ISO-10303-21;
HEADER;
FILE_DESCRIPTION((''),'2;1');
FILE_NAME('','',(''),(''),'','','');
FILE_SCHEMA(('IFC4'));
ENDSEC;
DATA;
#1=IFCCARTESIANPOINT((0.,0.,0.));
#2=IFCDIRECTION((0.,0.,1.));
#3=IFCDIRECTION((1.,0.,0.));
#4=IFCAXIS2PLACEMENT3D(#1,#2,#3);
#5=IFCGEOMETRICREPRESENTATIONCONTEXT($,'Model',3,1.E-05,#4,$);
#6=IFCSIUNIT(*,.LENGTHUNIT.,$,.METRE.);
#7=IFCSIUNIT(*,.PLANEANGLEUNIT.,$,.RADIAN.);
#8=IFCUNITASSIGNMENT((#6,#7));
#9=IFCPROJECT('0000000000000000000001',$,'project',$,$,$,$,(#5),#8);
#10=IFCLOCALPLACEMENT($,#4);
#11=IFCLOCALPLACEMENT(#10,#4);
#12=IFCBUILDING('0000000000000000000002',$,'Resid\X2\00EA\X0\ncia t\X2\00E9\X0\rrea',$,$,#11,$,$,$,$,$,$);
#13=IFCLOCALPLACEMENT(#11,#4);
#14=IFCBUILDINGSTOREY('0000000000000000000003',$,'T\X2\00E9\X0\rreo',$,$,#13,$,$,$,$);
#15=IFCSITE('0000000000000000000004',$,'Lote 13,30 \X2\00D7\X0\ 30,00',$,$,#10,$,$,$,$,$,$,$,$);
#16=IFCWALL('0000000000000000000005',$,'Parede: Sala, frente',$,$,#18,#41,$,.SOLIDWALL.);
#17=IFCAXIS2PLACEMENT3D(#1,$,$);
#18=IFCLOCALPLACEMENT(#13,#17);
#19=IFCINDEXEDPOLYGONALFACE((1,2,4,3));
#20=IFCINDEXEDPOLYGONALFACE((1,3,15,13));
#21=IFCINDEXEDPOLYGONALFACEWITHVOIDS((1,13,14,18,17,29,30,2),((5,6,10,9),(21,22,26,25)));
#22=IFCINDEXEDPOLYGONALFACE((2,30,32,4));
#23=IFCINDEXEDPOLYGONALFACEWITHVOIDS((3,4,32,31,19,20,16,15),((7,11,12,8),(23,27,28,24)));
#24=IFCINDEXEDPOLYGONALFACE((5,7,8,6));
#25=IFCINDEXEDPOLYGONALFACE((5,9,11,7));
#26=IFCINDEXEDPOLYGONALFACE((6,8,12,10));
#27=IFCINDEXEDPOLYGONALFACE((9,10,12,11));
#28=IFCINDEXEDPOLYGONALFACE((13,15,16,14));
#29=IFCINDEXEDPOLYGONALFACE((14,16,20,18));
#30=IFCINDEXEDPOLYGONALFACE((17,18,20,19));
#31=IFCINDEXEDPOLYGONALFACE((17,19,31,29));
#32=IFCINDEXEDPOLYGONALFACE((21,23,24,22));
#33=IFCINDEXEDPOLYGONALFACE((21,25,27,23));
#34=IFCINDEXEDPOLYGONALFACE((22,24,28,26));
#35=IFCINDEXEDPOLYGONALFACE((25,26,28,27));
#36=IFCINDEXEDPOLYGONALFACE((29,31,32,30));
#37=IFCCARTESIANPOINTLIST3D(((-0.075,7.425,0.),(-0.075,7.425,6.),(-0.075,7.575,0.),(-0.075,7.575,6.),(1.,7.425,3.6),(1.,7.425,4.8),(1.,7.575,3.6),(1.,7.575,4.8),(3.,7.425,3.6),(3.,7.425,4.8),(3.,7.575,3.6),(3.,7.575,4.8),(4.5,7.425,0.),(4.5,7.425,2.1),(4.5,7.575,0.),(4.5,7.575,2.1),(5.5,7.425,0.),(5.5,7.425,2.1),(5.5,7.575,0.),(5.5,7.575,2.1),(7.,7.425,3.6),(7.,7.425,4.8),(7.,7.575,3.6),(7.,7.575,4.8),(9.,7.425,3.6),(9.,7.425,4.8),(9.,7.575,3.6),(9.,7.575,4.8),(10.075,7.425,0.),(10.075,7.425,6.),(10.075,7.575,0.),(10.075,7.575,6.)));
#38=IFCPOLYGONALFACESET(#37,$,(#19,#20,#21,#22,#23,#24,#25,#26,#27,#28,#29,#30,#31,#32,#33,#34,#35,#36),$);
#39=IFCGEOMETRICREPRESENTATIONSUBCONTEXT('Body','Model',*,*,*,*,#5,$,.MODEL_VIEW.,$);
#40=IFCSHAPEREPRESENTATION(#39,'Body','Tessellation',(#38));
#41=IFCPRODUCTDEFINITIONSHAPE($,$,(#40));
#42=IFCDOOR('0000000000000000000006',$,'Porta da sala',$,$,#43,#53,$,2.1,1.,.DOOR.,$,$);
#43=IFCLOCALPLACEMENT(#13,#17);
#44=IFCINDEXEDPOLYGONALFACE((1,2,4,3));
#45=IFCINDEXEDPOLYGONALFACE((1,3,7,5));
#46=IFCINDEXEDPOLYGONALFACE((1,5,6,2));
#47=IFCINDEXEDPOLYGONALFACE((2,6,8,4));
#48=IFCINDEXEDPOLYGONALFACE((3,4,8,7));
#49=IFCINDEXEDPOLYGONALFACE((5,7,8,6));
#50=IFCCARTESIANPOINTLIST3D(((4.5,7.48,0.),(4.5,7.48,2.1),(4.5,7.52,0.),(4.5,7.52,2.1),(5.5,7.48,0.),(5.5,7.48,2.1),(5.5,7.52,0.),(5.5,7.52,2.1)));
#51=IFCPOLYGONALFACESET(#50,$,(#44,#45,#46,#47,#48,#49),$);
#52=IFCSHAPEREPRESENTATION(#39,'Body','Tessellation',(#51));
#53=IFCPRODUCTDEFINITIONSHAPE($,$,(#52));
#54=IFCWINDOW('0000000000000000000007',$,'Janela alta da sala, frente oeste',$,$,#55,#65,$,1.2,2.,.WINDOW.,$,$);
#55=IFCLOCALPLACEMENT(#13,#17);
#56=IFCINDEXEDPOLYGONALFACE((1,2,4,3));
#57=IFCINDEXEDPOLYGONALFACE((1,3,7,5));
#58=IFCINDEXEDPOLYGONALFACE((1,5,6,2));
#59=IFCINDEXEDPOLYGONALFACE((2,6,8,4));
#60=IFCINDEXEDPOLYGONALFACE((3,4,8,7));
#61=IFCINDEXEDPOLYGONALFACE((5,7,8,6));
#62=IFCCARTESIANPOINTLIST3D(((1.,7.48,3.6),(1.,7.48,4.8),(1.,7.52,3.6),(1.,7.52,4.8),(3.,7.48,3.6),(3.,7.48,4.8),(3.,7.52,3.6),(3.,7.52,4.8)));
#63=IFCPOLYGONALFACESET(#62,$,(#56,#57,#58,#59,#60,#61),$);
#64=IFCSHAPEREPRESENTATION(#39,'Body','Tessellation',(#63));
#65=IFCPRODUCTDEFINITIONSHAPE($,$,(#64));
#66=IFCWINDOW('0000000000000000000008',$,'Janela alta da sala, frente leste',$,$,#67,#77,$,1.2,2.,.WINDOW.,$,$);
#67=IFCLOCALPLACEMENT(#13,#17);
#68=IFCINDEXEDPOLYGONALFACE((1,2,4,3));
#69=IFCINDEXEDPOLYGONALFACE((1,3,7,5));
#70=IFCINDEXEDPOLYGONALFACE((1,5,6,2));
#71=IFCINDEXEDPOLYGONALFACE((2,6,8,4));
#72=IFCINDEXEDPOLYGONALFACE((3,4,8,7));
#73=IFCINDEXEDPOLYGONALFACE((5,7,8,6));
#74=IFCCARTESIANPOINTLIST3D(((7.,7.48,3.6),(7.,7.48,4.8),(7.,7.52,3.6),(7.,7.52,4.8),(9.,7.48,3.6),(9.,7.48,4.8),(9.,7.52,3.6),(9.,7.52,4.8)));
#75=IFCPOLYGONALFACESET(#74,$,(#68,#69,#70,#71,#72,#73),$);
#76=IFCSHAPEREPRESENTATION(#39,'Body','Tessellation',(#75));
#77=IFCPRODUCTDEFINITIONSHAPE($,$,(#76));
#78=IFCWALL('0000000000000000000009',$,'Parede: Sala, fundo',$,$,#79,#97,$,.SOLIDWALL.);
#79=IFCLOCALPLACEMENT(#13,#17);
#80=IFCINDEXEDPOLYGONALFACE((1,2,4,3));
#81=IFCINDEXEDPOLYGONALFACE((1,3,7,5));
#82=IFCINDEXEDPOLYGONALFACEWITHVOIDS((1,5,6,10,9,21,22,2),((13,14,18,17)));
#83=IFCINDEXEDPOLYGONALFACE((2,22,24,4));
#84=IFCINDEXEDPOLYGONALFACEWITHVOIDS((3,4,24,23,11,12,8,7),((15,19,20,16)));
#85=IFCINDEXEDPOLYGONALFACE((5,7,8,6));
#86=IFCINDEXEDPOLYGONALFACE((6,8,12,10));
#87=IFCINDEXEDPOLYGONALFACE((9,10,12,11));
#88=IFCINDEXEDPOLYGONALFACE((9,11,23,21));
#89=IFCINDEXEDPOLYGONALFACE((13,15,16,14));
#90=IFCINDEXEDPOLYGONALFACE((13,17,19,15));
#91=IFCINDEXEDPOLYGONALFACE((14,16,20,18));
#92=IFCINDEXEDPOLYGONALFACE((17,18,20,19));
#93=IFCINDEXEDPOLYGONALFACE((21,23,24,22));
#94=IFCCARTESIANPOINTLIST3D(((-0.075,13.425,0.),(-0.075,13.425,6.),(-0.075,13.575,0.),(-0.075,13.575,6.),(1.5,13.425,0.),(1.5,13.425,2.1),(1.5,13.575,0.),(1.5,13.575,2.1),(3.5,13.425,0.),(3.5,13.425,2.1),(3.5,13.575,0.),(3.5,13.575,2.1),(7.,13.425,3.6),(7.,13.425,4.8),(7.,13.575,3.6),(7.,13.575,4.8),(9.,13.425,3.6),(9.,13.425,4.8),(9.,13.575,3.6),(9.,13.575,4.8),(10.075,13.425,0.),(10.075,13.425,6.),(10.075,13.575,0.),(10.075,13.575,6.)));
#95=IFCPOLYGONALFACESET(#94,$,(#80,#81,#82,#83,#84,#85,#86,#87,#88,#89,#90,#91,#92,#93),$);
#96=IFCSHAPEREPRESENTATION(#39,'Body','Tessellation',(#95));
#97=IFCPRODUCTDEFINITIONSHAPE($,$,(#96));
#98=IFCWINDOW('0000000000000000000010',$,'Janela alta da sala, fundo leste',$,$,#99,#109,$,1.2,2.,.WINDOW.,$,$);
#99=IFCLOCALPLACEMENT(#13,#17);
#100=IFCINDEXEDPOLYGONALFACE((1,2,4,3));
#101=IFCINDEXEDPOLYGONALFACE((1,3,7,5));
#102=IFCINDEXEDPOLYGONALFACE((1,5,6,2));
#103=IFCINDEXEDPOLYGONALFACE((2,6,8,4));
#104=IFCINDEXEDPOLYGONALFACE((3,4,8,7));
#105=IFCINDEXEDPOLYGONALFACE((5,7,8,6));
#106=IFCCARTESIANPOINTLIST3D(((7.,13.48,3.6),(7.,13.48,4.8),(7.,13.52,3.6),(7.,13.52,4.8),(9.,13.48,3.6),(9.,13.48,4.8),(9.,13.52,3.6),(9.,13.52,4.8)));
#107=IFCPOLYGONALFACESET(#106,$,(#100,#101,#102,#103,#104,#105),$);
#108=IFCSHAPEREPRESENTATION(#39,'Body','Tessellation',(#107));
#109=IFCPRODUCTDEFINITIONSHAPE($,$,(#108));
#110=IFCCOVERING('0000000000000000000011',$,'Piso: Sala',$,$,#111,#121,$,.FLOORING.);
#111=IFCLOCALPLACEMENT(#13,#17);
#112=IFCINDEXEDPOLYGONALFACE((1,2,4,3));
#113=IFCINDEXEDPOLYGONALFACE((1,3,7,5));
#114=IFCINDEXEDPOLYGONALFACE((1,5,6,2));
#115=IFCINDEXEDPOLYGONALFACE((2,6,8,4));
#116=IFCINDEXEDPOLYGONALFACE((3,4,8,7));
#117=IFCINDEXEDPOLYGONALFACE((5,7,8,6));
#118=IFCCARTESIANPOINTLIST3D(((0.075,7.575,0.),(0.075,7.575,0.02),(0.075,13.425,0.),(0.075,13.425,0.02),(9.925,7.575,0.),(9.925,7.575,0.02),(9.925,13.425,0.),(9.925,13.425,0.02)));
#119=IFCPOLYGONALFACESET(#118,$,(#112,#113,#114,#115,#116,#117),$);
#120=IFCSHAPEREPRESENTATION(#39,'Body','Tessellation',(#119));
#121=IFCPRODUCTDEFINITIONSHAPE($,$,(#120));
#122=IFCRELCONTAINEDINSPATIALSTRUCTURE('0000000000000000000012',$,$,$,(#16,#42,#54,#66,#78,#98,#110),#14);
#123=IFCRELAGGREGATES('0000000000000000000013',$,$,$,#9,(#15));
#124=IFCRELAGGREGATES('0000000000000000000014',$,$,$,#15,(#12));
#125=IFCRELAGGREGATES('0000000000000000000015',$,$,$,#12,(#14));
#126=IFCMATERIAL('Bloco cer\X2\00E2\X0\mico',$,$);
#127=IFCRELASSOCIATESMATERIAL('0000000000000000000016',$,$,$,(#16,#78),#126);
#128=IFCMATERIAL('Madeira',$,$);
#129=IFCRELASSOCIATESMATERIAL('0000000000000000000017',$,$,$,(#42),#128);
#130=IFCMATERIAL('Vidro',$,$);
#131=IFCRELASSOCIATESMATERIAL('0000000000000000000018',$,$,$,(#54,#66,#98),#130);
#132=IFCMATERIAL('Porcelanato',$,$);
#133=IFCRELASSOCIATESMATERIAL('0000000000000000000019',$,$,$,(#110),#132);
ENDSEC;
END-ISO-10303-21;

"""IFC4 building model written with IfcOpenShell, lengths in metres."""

from ifc_helpers import new_model, si_unit, frame, origin_with_axes, place, context, subcontext, project, spatial, line, indexed_curve, outline, extrude, material, element, fill, save


model = new_model("IFC4")

# Units and contexts
model_context = context("Model", 3, precision=1e-05, world=origin_with_axes())
body_context = subcontext(model_context, "Body", "Model", "MODEL_VIEW")
ifc_project = project(units=[si_unit("LENGTHUNIT", "METRE"), si_unit("PLANEANGLEUNIT", "RADIAN")], contexts=[model_context])

# Site, building, storey
site_placement = place(None, origin_with_axes())
site = spatial("IfcSite", under=ifc_project, at=site_placement, Name="Lote 13,30 × 30,00")
building_placement = place(site_placement, origin_with_axes())
building = spatial("IfcBuilding", under=site, at=building_placement, Name="Residência térrea")
storey_placement = place(building_placement, origin_with_axes())
storey = spatial("IfcBuildingStorey", under=building, at=storey_placement, Name="Térreo")

# Shared definitions
ifc_material_1 = material(Name="Concreto armado")

# Shared definitions
ifc_material_2 = material(Name="Bloco cerâmico")
ifc_material_3 = material(Name="Vidro")

# Wall, openings, door, windows
wall_1_placement = place(storey_placement, frame((-0.075, 7.425, 0.0), z_axis=(0.0, 0.0, 1.0), x_axis=(1.0, 0.0, 0.0)))
wall_1 = element("IfcWall", 1, at=wall_1_placement, inside=storey, material=ifc_material_2, Name="Parede: Sala, frente", PredefinedType="SOLIDWALL", context=body_context, shape_type="SweptSolid", body=[
    extrude(outline(indexed_curve([(0.0, 0.0), (10.15, 0.0), (10.15, 0.15), (0.0, 0.15)], segments=[line(1, 2, 3, 4, 1)])), origin_with_axes(), (0.0, 0.0, 1.0), 6.0),
])
opening_1_placement = place(wall_1_placement, frame((4.575, -0.05, 0.0), z_axis=(0.0, 0.0, 1.0), x_axis=(1.0, 0.0, 0.0)))
opening_1 = element("IfcOpeningElement", 2, at=opening_1_placement, cuts=wall_1, material=ifc_material_1, PredefinedType="OPENING", context=body_context, shape_type="SweptSolid", body=[
    extrude(outline(indexed_curve([(0.0, 0.0), (1.0, 0.0), (1.0, 0.25), (0.0, 0.25)], segments=[line(1, 2, 3, 4, 1)])), origin_with_axes(), (0.0, 0.0, 1.0), 2.1),
])
opening_2_placement = place(wall_1_placement, frame((1.075, -0.05, 3.6), z_axis=(0.0, 0.0, 1.0), x_axis=(1.0, 0.0, 0.0)))
opening_2 = element("IfcOpeningElement", 3, at=opening_2_placement, cuts=wall_1, material=ifc_material_1, PredefinedType="OPENING", context=body_context, shape_type="SweptSolid", body=[
    extrude(outline(indexed_curve([(0.0, 0.0), (2.0, 0.0), (2.0, 0.25), (0.0, 0.25)], segments=[line(1, 2, 3, 4, 1)])), origin_with_axes(), (0.0, 0.0, 1.0), 1.2),
])
opening_3_placement = place(wall_1_placement, frame((7.075, -0.05, 3.6), z_axis=(0.0, 0.0, 1.0), x_axis=(1.0, 0.0, 0.0)))
opening_3 = element("IfcOpeningElement", 4, at=opening_3_placement, cuts=wall_1, material=ifc_material_1, PredefinedType="OPENING", context=body_context, shape_type="SweptSolid", body=[
    extrude(outline(indexed_curve([(0.0, 0.0), (2.0, 0.0), (2.0, 0.25), (0.0, 0.25)], segments=[line(1, 2, 3, 4, 1)])), origin_with_axes(), (0.0, 0.0, 1.0), 1.2),
])
ifc_material_4 = material(Name="Madeira")
door_placement = place(storey_placement, frame((4.5, 7.48, 0.0), z_axis=(0.0, 0.0, 1.0), x_axis=(1.0, 0.0, 0.0)))
door = element("IfcDoor", 5, at=door_placement, inside=storey, material=ifc_material_4, Name="Porta da sala", OverallHeight=2.1, OverallWidth=1.0, PredefinedType="DOOR", context=body_context, shape_type="SweptSolid", body=[
    extrude(outline(indexed_curve([(0.0, 0.0), (1.0, 0.0), (1.0, 0.04), (0.0, 0.04)], segments=[line(1, 2, 3, 4, 1)])), origin_with_axes(), (0.0, 0.0, 1.0), 2.1),
])
fill(opening_1, door)
window_1_placement = place(storey_placement, frame((1.0, 7.48, 3.6), z_axis=(0.0, 0.0, 1.0), x_axis=(1.0, 0.0, 0.0)))
window_1 = element("IfcWindow", 6, at=window_1_placement, inside=storey, material=ifc_material_3, Name="Janela alta da sala, frente oeste", OverallHeight=1.2, OverallWidth=2.0, PredefinedType="WINDOW", context=body_context, shape_type="SweptSolid", body=[
    extrude(outline(indexed_curve([(0.0, 0.0), (2.0, 0.0), (2.0, 0.04), (0.0, 0.04)], segments=[line(1, 2, 3, 4, 1)])), origin_with_axes(), (0.0, 0.0, 1.0), 1.2),
])
fill(opening_2, window_1)
window_2_placement = place(storey_placement, frame((7.0, 7.48, 3.6), z_axis=(0.0, 0.0, 1.0), x_axis=(1.0, 0.0, 0.0)))
window_2 = element("IfcWindow", 7, at=window_2_placement, inside=storey, material=ifc_material_3, Name="Janela alta da sala, frente leste", OverallHeight=1.2, OverallWidth=2.0, PredefinedType="WINDOW", context=body_context, shape_type="SweptSolid", body=[
    extrude(outline(indexed_curve([(0.0, 0.0), (2.0, 0.0), (2.0, 0.04), (0.0, 0.04)], segments=[line(1, 2, 3, 4, 1)])), origin_with_axes(), (0.0, 0.0, 1.0), 1.2),
])
fill(opening_3, window_2)

# Wall, openings, window
wall_2_placement = place(storey_placement, frame((-0.075, 13.425, 0.0), z_axis=(0.0, 0.0, 1.0), x_axis=(1.0, 0.0, 0.0)))
wall_2 = element("IfcWall", 8, at=wall_2_placement, inside=storey, material=ifc_material_2, Name="Parede: Sala, fundo", PredefinedType="SOLIDWALL", context=body_context, shape_type="SweptSolid", body=[
    extrude(outline(indexed_curve([(0.0, 0.0), (10.15, 0.0), (10.15, 0.15), (0.0, 0.15)], segments=[line(1, 2, 3, 4, 1)])), origin_with_axes(), (0.0, 0.0, 1.0), 6.0),
])
opening_4_placement = place(wall_2_placement, frame((1.575, -0.05, 0.0), z_axis=(0.0, 0.0, 1.0), x_axis=(1.0, 0.0, 0.0)))
element("IfcOpeningElement", 9, at=opening_4_placement, cuts=wall_2, material=ifc_material_1, PredefinedType="OPENING", context=body_context, shape_type="SweptSolid", body=[
    extrude(outline(indexed_curve([(0.0, 0.0), (2.0, 0.0), (2.0, 0.25), (0.0, 0.25)], segments=[line(1, 2, 3, 4, 1)])), origin_with_axes(), (0.0, 0.0, 1.0), 2.1),
])
opening_5_placement = place(wall_2_placement, frame((7.075, -0.05, 3.6), z_axis=(0.0, 0.0, 1.0), x_axis=(1.0, 0.0, 0.0)))
opening_5 = element("IfcOpeningElement", 10, at=opening_5_placement, cuts=wall_2, material=ifc_material_1, PredefinedType="OPENING", context=body_context, shape_type="SweptSolid", body=[
    extrude(outline(indexed_curve([(0.0, 0.0), (2.0, 0.0), (2.0, 0.25), (0.0, 0.25)], segments=[line(1, 2, 3, 4, 1)])), origin_with_axes(), (0.0, 0.0, 1.0), 1.2),
])
window_3_placement = place(storey_placement, frame((7.0, 13.48, 3.6), z_axis=(0.0, 0.0, 1.0), x_axis=(1.0, 0.0, 0.0)))
window_3 = element("IfcWindow", 11, at=window_3_placement, inside=storey, material=ifc_material_3, Name="Janela alta da sala, fundo leste", OverallHeight=1.2, OverallWidth=2.0, PredefinedType="WINDOW", context=body_context, shape_type="SweptSolid", body=[
    extrude(outline(indexed_curve([(0.0, 0.0), (2.0, 0.0), (2.0, 0.04), (0.0, 0.04)], segments=[line(1, 2, 3, 4, 1)])), origin_with_axes(), (0.0, 0.0, 1.0), 1.2),
])
fill(opening_5, window_3)

# Covering
ifc_material_5 = material(Name="Porcelanato")
covering_placement = place(storey_placement, frame((0.075, 7.575, 0.0), z_axis=(0.0, 0.0, 1.0), x_axis=(1.0, 0.0, 0.0)))
element("IfcCovering", 12, at=covering_placement, inside=storey, material=ifc_material_5, Name="Piso: Sala", PredefinedType="FLOORING", context=body_context, shape_type="SweptSolid", body=[
    extrude(outline(indexed_curve([(0.0, 0.0), (9.85, 0.0), (9.85, 5.85), (0.0, 5.85)], segments=[line(1, 2, 3, 4, 1)])), origin_with_axes(), (0.0, 0.0, 1.0), 0.02),
])

save(model, "model.ifc")
